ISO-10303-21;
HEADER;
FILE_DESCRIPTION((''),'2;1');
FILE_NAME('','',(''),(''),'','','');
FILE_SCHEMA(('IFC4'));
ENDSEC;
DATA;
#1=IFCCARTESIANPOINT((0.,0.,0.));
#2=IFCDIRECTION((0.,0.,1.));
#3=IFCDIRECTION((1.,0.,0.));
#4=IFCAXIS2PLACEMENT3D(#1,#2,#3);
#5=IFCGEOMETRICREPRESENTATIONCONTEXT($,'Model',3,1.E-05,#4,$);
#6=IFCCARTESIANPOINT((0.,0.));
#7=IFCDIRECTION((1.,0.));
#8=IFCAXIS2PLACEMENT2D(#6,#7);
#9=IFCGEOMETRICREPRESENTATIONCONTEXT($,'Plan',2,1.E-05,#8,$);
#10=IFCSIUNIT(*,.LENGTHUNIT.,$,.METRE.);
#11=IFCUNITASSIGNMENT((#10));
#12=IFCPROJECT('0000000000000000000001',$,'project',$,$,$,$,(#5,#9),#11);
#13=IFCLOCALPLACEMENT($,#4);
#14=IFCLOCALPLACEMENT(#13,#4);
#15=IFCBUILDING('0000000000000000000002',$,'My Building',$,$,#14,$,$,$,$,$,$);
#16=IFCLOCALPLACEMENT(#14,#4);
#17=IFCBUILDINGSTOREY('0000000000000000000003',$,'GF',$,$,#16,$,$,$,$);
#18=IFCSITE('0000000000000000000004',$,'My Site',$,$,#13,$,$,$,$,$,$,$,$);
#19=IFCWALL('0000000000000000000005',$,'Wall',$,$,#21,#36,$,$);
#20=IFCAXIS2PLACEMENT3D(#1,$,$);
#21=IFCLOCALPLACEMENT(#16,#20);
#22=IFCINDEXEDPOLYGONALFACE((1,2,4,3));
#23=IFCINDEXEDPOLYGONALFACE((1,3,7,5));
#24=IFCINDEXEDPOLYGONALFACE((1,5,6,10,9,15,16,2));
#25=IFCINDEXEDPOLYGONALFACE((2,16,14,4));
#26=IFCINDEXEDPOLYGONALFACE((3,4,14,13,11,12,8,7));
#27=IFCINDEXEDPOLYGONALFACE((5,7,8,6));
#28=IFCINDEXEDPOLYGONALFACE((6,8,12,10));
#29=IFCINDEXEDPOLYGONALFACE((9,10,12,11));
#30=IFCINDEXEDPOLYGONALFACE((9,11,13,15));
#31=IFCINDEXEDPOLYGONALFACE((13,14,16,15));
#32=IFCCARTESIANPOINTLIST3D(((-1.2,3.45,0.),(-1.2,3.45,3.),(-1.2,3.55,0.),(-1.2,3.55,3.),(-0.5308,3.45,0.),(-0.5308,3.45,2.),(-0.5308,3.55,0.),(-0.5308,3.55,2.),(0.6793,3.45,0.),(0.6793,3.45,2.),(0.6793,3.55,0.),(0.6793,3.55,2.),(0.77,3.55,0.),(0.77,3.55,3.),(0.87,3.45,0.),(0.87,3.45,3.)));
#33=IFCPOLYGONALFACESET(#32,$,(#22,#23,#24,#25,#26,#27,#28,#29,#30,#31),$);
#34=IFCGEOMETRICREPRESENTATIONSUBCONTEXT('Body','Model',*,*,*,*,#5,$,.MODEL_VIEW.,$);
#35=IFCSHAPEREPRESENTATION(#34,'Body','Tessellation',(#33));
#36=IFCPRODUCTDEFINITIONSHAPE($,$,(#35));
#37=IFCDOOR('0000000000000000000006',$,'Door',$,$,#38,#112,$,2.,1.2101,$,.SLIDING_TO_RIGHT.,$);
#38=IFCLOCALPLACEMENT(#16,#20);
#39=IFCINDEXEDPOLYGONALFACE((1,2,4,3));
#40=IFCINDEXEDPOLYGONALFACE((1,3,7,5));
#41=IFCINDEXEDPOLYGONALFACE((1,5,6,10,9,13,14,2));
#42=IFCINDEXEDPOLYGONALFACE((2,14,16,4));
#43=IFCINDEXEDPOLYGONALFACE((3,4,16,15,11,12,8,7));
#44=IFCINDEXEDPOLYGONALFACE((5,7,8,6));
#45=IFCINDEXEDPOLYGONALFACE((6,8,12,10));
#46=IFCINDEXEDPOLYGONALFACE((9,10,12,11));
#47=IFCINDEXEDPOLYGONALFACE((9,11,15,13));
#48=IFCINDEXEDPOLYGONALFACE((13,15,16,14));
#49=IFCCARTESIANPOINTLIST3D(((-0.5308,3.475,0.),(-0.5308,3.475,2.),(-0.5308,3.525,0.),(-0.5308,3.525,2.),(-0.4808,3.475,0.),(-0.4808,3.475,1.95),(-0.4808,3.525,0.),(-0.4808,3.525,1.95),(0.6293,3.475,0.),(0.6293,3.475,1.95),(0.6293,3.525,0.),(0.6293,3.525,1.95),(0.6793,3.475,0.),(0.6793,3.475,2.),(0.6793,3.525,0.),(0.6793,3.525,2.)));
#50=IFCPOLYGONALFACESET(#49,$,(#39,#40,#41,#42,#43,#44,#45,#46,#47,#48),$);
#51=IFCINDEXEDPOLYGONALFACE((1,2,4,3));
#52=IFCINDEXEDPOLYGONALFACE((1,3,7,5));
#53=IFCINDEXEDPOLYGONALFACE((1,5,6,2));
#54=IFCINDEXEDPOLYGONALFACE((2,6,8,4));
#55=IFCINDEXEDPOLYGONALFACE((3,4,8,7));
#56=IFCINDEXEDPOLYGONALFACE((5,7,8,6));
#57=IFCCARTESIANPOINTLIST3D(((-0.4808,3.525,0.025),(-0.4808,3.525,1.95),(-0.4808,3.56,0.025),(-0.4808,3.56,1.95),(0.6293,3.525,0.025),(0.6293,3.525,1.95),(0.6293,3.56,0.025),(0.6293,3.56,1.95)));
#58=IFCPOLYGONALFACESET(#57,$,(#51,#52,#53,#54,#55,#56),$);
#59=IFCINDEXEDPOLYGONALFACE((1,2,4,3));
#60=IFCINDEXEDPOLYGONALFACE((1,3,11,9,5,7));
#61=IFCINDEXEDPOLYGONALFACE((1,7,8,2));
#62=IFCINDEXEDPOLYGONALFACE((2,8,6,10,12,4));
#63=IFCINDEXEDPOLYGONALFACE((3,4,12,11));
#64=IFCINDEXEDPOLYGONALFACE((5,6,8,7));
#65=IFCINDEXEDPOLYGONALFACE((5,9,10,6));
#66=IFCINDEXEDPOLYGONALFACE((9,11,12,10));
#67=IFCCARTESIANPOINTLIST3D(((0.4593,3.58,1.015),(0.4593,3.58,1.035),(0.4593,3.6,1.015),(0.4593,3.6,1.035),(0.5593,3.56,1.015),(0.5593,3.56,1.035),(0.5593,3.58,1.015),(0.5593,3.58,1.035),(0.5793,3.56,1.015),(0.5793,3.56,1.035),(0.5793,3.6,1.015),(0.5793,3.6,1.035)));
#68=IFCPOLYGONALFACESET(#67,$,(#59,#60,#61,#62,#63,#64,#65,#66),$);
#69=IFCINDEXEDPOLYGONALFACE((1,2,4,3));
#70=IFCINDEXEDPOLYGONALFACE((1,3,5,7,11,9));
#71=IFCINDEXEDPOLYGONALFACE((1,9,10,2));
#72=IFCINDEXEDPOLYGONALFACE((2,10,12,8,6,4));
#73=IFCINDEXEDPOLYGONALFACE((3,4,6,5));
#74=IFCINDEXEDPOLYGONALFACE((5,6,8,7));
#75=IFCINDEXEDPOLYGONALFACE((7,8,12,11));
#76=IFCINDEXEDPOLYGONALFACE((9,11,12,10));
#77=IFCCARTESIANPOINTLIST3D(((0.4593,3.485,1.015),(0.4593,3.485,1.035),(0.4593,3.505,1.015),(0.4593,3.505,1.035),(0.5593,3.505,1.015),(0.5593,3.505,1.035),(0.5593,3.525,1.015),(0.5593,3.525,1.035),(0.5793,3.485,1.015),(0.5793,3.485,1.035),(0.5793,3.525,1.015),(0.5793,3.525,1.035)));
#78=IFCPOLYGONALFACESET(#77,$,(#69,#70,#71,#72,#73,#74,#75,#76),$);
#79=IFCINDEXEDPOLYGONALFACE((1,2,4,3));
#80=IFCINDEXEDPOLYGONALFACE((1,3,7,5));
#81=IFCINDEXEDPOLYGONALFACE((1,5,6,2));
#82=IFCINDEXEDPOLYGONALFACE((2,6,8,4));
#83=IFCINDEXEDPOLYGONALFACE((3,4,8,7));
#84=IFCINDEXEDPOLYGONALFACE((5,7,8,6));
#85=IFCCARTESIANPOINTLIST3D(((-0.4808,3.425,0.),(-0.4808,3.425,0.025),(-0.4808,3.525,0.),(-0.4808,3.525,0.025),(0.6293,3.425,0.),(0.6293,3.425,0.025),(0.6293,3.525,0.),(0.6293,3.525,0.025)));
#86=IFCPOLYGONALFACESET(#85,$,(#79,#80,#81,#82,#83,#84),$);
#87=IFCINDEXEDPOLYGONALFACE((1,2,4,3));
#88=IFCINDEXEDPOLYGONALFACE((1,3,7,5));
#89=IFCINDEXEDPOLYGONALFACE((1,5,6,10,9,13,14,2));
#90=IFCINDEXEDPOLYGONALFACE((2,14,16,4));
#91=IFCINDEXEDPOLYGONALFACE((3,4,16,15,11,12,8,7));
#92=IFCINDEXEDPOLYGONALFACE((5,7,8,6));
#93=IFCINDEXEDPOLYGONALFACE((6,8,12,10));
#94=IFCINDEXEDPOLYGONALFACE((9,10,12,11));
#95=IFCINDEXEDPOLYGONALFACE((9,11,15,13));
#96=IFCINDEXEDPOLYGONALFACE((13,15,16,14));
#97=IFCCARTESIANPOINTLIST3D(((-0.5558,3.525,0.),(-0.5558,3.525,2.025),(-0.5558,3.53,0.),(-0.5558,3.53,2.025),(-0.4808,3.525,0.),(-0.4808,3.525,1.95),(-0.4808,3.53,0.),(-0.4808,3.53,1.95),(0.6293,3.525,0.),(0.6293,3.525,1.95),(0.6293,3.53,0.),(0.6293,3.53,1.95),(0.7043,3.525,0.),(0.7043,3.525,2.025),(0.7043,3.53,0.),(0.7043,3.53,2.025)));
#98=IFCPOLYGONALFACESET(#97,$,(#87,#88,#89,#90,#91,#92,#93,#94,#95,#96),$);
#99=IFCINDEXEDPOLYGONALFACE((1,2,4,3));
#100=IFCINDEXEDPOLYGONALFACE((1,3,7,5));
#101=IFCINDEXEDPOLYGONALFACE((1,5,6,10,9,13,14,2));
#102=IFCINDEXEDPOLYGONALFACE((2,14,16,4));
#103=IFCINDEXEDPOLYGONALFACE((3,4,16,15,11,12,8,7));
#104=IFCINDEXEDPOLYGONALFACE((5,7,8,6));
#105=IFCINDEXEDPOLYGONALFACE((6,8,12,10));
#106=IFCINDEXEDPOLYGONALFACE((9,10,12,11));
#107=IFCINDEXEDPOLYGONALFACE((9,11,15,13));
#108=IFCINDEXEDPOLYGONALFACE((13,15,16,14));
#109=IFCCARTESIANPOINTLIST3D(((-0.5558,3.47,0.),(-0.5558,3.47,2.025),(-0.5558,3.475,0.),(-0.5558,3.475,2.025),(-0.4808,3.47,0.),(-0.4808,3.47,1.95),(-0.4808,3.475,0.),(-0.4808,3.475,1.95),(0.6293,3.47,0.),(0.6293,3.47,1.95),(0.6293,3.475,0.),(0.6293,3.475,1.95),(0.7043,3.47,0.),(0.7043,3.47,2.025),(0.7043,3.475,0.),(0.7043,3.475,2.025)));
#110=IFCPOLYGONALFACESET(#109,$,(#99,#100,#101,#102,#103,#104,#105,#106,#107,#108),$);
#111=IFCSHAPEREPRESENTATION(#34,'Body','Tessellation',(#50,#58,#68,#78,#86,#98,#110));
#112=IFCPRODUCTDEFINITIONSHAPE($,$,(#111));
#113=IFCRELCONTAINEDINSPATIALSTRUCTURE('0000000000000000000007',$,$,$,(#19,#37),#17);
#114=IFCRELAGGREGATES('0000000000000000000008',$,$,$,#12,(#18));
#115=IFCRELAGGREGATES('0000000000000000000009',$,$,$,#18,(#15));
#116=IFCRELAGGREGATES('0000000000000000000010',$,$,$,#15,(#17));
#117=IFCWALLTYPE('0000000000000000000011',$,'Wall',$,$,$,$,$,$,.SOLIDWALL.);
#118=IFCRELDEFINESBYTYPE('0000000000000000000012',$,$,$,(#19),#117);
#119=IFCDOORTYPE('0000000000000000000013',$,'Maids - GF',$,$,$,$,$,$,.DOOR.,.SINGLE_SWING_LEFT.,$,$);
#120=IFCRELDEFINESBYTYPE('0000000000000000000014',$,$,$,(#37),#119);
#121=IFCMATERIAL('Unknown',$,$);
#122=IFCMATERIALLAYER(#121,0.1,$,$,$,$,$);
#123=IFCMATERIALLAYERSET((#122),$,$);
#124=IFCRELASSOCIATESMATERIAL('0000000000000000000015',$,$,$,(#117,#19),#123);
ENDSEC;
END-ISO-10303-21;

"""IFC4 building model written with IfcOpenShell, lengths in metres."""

from ifc_helpers import new_model, entity, si_unit, frame, origin_with_axes, origin_2d_with_axis, place, context, subcontext, project, spatial, line, indexed_curve, outline, extrude, shape, source, transform, mapped, material, layer, layer_set, layer_usage, type_object, type_shapes, element, fill, save


model = new_model("IFC4")

# Units and contexts
model_context = context("Model", 3, precision=1e-05, world=origin_with_axes())
plan_context = context("Plan", 2, precision=1e-05, world=origin_2d_with_axis())
body_context_1 = subcontext(model_context, "Body", "Model", "MODEL_VIEW")
body_context_2 = subcontext(plan_context, "Body", "Plan", "PLAN_VIEW")
ifc_project = project(units=[si_unit("LENGTHUNIT", "METRE")], contexts=[model_context, plan_context])

# Site, building, storey
site_placement = place(None, origin_with_axes())
site = spatial("IfcSite", under=ifc_project, at=site_placement, Name="My Site")
building_placement = place(site_placement, origin_with_axes())
building = spatial("IfcBuilding", under=site, at=building_placement, Name="My Building")
storey_placement = place(building_placement, origin_with_axes())
storey = spatial("IfcBuildingStorey", under=building, at=storey_placement, Name="GF")

# Shared definitions
ifc_material = material(Name="Unknown")

# Shared definitions
ifc_layer_1 = layer(ifc_material, 0.1)
ifc_layer_set_1 = layer_set([ifc_layer_1])
wall_type = type_object("IfcWallType", Name="Wall", PredefinedType="SOLIDWALL", material=ifc_layer_set_1)

# Wall, opening, door
ifc_layer_usage_1 = layer_usage(ifc_layer_set_1, "AXIS2", "POSITIVE", 0.0)
wall_1_placement = place(storey_placement, frame((0.77, 3.55, 0.0), z_axis=(0.0, 0.0, 1.0), x_axis=(-1.0, 0.0, 0.0)))
wall_1 = element("IfcWall", 1, at=wall_1_placement, inside=storey, type_object=wall_type, material=ifc_layer_usage_1, Name="Wall", context=body_context_1, shape_type="SweptSolid", body=[
    extrude(outline(indexed_curve([(0.0, 0.0), (-0.1, 0.1), (1.97, 0.1), (1.97, 0.0)], segments=[line(1, 2, 3, 4, 1)])), origin_with_axes(), (0.0, 0.0, 1.0), 3.0),
])
shared_shape_1 = source(origin_with_axes(), body_context_1, "Body", "SweptSolid", [
    extrude(outline(indexed_curve([(0.0, 0.0), (1.2101, 0.0), (1.2101, 2.0), (0.0, 2.0)], segments=[line(1, 2, 3, 4, 1)])), frame((0.0, -0.6, 0.0), z_axis=(0.0, -1.0, 0.0), x_axis=(1.0, 0.0, 0.0)), (0.0, 0.0, -1.0), 1.2),
])
opening_1_placement = place(wall_1_placement, frame((0.0907, 0.025, 0.0), z_axis=(0.0, 0.0, 1.0), x_axis=(1.0, 0.0, 0.0)))
opening_1 = element("IfcOpeningElement", 2, at=opening_1_placement, cuts=wall_1, PredefinedType="OPENING", context=body_context_1, shape_type="MappedRepresentation", body=[
    mapped(shared_shape_1, transform((0.0, 0.0, 0.0), x_axis=(1.0, 0.0, 0.0), y_axis=(0.0, 1.0, 0.0), z_axis=(0.0, 0.0, 1.0), scale=1.0)),
])
door_type_1 = type_object("IfcDoorType", Name="Maids - GF", OperationType="SINGLE_SWING_LEFT", PredefinedType="DOOR")
shared_shape_2 = source(origin_with_axes(), body_context_1, "Body", "SweptSolid", [
    extrude(outline(indexed_curve([(0.0, 0.0), (0.0, 2.0), (1.2101, 2.0), (1.2101, 0.0), (1.1601, 0.0), (1.1601, 1.95), (0.05, 1.95), (0.05, 0.0)], segments=[line(1, 2, 3, 4, 5, 6, 7, 8, 1)])), frame((0.0, 0.0, 0.0), z_axis=(0.0, -1.0, 0.0), x_axis=(1.0, 0.0, 0.0)), (0.0, 0.0, -1.0), 0.05),
    extrude(outline(indexed_curve([(0.0, 0.0), (1.1101, 0.0), (1.1101, 0.035), (0.0, 0.035)], segments=[line(1, 2, 3, 4, 1)])), frame((0.05, -0.035, 0.025), z_axis=(0.0, 0.0, 1.0), x_axis=(1.0, 0.0, 0.0)), (0.0, 0.0, 1.0), 1.925),
    extrude(outline(indexed_curve([(0.0, 0.0), (0.0, -0.04), (0.12, -0.04), (0.12, -0.02), (0.02, -0.02), (0.02, 0.0)], segments=[line(1, 2, 3, 4, 5, 6, 1)])), frame((0.1, -0.035, 1.015), z_axis=(0.0, 0.0, 1.0), x_axis=(1.0, 0.0, 0.0)), (0.0, 0.0, 1.0), 0.02),
    extrude(outline(indexed_curve([(0.0, 0.0), (0.0, 0.04), (0.12, 0.04), (0.12, 0.02), (0.02, 0.02), (0.02, 0.0)], segments=[line(1, 2, 3, 4, 5, 6, 1)])), frame((0.1, 0.0, 1.015), z_axis=(0.0, 0.0, 1.0), x_axis=(1.0, 0.0, 0.0)), (0.0, 0.0, 1.0), 0.02),
    extrude(outline(indexed_curve([(0.0, 0.0), (1.1101, 0.0), (1.1101, 0.1), (0.0, 0.1)], segments=[line(1, 2, 3, 4, 1)])), frame((0.05, 0.0, 0.0), z_axis=(0.0, 0.0, 1.0), x_axis=(1.0, 0.0, 0.0)), (0.0, 0.0, 1.0), 0.025),
    extrude(outline(indexed_curve([(0.0, 0.0), (0.0, 2.025), (1.2601, 2.025), (1.2601, 0.0), (1.1851, 0.0), (1.1851, 1.95), (0.075, 1.95), (0.075, 0.0)], segments=[line(1, 2, 3, 4, 5, 6, 7, 8, 1)])), frame((-0.025, -0.005, 0.0), z_axis=(0.0, -1.0, 0.0), x_axis=(1.0, 0.0, 0.0)), (0.0, 0.0, -1.0), 0.005),
    extrude(outline(indexed_curve([(0.0, 0.0), (0.0, 2.025), (1.2601, 2.025), (1.2601, 0.0), (1.1851, 0.0), (1.1851, 1.95), (0.075, 1.95), (0.075, 0.0)], segments=[line(1, 2, 3, 4, 5, 6, 7, 8, 1)])), frame((-0.025, 0.05, 0.0), z_axis=(0.0, -1.0, 0.0), x_axis=(1.0, 0.0, 0.0)), (0.0, 0.0, -1.0), 0.005),
])
shared_shape_3 = source(origin_with_axes(), body_context_2, "Body", "Curve2D", [
    entity("IfcIndexedPolyCurve", entity("IfcCartesianPointList2D", [[0.0, 0.0], [0.05, 0.0], [0.05, 0.05], [0.0, 0.05]]), [entity("IfcLineIndex", [1, 2, 3, 4, 1])]),
    entity("IfcIndexedPolyCurve", entity("IfcCartesianPointList2D", [[1.2101, 0.0], [1.1601, 0.0], [1.1601, 0.05], [1.2101, 0.05]]), [entity("IfcLineIndex", [1, 2, 3, 4, 1])]),
    entity("IfcIndexedPolyCurve", entity("IfcCartesianPointList2D", [[1.7151, -0.035], [0.605, -0.035], [0.605, 0.0], [1.7151, 0.0]]), [entity("IfcLineIndex", [1, 2, 3, 4, 1])]),
])
type_shapes(door_type_1, [shared_shape_2, shared_shape_3])
door_1_placement = place(opening_1_placement, frame((0.0, 0.0, 0.0), z_axis=(0.0, 0.0, 1.0), x_axis=(1.0, 0.0, 0.0)))
door_1 = element("IfcDoor", 3, at=door_1_placement, inside=storey, type_object=door_type_1, Name="Door", OperationType="SLIDING_TO_RIGHT", OverallHeight=2.0, OverallWidth=1.2101, shapes=[
    shape(body_context_1, "Body", "MappedRepresentation", [mapped(shared_shape_2, transform((0.0, 0.0, 0.0), x_axis=(1.0, 0.0, 0.0), y_axis=(0.0, 1.0, 0.0), z_axis=(0.0, 0.0, 1.0), scale=1.0))]),
    shape(body_context_2, "Body", "MappedRepresentation", [mapped(shared_shape_3, transform((0.0, 0.0, 0.0), x_axis=(1.0, 0.0, 0.0), y_axis=(0.0, 1.0, 0.0), z_axis=(0.0, 0.0, 1.0), scale=1.0))]),
])
fill(opening_1, door_1)

save(model, "model.ifc")
